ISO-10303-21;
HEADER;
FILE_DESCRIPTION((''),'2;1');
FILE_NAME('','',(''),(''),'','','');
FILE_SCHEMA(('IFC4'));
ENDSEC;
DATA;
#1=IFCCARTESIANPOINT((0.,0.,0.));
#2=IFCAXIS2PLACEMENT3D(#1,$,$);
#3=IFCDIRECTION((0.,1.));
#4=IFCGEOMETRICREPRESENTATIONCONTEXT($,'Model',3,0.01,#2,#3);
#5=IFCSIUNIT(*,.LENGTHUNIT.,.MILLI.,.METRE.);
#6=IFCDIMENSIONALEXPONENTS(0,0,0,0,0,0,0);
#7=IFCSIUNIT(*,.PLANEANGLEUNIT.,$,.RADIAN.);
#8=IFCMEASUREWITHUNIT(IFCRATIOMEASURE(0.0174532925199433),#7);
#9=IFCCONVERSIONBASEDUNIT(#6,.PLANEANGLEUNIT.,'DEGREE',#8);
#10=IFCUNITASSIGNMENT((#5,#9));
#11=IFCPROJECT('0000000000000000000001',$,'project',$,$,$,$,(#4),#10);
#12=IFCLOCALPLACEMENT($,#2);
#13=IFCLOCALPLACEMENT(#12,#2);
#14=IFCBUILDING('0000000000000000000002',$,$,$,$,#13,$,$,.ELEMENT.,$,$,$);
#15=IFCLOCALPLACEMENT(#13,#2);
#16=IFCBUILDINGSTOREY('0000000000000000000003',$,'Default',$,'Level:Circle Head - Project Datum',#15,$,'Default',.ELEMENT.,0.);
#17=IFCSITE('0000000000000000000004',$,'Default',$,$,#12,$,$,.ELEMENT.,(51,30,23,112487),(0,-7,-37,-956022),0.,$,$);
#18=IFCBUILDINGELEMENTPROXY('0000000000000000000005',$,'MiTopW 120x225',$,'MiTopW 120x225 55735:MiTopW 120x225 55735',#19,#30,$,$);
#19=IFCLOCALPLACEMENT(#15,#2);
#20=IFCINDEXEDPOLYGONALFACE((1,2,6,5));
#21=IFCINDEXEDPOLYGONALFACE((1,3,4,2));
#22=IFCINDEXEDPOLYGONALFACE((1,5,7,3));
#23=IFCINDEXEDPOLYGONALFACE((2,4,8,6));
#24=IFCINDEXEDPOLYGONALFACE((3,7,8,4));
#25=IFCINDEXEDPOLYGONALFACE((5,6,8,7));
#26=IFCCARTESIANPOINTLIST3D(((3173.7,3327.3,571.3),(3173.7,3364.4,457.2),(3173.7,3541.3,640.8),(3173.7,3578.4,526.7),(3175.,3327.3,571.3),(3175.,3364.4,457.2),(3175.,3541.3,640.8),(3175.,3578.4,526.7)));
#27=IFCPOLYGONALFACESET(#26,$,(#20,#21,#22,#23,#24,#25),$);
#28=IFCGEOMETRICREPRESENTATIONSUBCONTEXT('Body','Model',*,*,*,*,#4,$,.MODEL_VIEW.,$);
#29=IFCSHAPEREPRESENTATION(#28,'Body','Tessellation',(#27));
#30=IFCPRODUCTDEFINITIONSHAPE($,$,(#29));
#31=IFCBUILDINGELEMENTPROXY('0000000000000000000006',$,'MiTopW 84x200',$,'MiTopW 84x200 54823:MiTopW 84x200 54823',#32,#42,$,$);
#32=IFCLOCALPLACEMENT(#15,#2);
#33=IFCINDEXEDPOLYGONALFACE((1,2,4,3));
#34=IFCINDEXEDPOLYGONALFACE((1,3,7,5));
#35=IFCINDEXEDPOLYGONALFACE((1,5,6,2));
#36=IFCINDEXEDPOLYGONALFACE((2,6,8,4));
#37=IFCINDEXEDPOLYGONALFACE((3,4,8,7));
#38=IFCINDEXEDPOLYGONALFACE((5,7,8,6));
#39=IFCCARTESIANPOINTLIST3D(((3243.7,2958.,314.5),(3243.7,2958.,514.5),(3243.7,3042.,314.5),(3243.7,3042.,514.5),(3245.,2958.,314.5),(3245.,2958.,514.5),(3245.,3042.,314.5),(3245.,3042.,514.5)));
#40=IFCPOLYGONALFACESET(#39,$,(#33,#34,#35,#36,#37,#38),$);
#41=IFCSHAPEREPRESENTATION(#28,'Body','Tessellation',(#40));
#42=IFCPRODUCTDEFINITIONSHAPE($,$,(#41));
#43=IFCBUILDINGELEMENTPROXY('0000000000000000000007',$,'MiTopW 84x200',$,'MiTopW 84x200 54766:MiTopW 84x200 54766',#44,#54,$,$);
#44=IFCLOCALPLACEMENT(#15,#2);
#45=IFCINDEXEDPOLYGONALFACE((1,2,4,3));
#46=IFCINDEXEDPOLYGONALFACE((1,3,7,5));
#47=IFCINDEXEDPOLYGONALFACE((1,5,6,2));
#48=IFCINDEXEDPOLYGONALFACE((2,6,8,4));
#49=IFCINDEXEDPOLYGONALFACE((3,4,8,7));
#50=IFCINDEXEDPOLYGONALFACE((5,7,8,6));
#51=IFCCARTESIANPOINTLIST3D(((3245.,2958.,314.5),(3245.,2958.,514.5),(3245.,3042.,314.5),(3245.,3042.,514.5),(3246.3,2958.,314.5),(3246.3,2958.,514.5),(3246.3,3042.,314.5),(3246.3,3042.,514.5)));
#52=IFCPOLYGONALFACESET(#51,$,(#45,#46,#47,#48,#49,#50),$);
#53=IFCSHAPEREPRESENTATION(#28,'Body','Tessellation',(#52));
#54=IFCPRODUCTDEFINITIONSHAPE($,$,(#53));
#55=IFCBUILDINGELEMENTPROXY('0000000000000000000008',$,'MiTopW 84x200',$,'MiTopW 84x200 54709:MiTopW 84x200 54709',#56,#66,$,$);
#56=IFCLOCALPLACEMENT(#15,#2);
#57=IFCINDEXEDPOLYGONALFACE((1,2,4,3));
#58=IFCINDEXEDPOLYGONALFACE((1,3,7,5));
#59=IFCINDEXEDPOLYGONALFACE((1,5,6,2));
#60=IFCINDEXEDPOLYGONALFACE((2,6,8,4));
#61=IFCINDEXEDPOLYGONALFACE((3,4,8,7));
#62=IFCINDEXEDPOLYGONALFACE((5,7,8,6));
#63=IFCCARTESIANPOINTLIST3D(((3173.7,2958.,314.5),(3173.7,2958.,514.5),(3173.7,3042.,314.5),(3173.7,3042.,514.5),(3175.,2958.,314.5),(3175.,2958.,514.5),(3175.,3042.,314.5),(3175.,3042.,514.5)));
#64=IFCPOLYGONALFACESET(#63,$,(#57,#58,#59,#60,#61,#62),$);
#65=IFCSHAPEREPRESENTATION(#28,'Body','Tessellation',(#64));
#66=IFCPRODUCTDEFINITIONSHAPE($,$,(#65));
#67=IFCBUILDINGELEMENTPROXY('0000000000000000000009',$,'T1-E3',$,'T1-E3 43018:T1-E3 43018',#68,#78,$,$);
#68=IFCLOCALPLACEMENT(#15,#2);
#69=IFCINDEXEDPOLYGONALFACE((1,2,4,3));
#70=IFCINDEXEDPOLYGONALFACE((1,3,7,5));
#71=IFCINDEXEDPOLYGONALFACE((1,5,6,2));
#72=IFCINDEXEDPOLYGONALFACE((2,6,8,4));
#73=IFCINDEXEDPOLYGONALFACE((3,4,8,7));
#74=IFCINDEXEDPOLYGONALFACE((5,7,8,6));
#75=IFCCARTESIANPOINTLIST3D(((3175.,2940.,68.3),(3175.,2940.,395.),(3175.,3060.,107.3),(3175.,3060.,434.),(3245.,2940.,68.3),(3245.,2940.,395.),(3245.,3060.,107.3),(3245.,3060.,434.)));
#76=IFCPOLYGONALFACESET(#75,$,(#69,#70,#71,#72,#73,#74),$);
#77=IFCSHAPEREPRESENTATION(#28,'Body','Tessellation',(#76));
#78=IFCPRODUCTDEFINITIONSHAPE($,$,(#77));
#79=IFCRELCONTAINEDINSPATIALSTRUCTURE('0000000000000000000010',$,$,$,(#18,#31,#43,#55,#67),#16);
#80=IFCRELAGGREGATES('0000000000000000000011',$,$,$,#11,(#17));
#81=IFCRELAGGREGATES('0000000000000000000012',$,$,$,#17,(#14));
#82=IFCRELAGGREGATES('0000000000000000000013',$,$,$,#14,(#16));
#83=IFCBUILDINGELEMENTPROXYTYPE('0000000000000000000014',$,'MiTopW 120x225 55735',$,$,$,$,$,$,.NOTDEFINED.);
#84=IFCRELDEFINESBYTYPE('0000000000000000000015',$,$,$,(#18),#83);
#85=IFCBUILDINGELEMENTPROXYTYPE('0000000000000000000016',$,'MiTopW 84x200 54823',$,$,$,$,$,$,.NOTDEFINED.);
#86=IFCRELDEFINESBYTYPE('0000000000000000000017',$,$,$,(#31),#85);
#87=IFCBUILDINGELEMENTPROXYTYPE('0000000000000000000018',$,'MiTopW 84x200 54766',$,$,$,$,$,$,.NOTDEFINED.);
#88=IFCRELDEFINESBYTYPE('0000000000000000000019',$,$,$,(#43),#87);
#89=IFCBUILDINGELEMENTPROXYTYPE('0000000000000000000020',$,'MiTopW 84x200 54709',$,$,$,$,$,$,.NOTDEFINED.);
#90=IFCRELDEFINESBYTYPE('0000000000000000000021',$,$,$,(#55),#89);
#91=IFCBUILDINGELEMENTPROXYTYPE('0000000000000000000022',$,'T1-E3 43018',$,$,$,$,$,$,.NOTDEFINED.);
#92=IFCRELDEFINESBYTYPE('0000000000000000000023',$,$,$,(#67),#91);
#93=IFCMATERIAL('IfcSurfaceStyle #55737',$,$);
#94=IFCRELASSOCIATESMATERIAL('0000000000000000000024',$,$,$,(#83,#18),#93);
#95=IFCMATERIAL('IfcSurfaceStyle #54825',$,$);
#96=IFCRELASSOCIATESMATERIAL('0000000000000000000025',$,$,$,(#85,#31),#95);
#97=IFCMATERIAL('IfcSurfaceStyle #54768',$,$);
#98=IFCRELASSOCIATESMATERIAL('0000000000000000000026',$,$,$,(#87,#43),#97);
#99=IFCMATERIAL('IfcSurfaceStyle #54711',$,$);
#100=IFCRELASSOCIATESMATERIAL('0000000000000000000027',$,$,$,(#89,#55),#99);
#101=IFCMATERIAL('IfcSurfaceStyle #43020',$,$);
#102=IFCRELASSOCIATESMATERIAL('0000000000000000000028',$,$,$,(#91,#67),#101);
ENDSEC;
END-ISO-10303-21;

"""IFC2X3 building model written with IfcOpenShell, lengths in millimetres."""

from ifc_helpers import new_model, entity, si_unit, converted_unit, direction, frame, frame_2d, origin, place, context, subcontext, project, spatial, polyline, rectangle, outline, extrude, source, transform, mapped, material, type_object, type_shapes, element, save


model = new_model("IFC2X3")

# Units and contexts
model_context = context("Model", 3, precision=0.01, world=origin(), true_north=direction((0.0, 1.0)))
body_context = subcontext(model_context, "Body", "Model", "MODEL_VIEW")
ifc_project = project(units=[si_unit("LENGTHUNIT", "METRE", prefix="MILLI"), converted_unit("PLANEANGLEUNIT", "DEGREE", entity("IfcRatioMeasure", 0.0174532925199433), si_unit("PLANEANGLEUNIT", "RADIAN"), dimensions=[0, 0, 0, 0, 0, 0, 0])], contexts=[model_context])

# Site, building, storey
site_placement = place(None, origin())
site = spatial("IfcSite", under=ifc_project, at=site_placement, Name="Default", CompositionType="ELEMENT", RefLatitude=(51, 30, 23, 112487), RefLongitude=(0, -7, -37, -956022), RefElevation=0.0)
building_placement = place(site_placement, origin())
building = spatial("IfcBuilding", under=site, at=building_placement, CompositionType="ELEMENT")
storey_placement = place(building_placement, origin())
storey = spatial("IfcBuildingStorey", under=building, at=storey_placement, Name="Default", ObjectType="Level:Circle Head - Project Datum", LongName="Default", CompositionType="ELEMENT", Elevation=0.0)

# Building element proxies
ifc_material_1 = material(Name="IfcSurfaceStyle #55737")
building_element_proxy_type_1 = type_object("IfcBuildingElementProxyType", Name="MiTopW 120x225 55735", PredefinedType="NOTDEFINED", material=ifc_material_1)
shared_shape_1 = source(origin(), body_context, "Body", "SweptSolid", [
    extrude(outline(polyline([(-112.5, -60.0), (112.5, -60.0), (112.5, 60.0), (-112.5, 60.0), (-112.5, -60.0)])), frame((112.5, 60.0, 0.0), z_axis=(0.0, 0.0, 1.0), x_axis=(-1.0, 0.0, 0.0)), (0.0, 0.0, 1.0), 1.3),
])
type_shapes(building_element_proxy_type_1, [shared_shape_1])
proxy_1_placement = place(building_placement, frame((3175.0, 3327.3, 571.3), z_axis=(-1.0, 0.0, 0.0), x_axis=(0.0, 0.951057, 0.309017)))
element("IfcBuildingElementProxy", 1, at=proxy_1_placement, inside=storey, type_object=building_element_proxy_type_1, material=ifc_material_1, Name="MiTopW 120x225", ObjectType="MiTopW 120x225 55735:MiTopW 120x225 55735", context=body_context, shape_type="MappedRepresentation", body=[
    mapped(shared_shape_1, transform((0.0, 0.0, 0.0), scale=1.0)),
])
ifc_material_2 = material(Name="IfcSurfaceStyle #54825")
building_element_proxy_type_2 = type_object("IfcBuildingElementProxyType", Name="MiTopW 84x200 54823", PredefinedType="NOTDEFINED", material=ifc_material_2)
shared_shape_2 = source(origin(), body_context, "Body", "SweptSolid", [
    extrude(rectangle(XDim=200.0, YDim=84.0, at=frame_2d((0.0, 0.0), x_axis=(1.0, 0.0))), frame((100.0, 42.0, 0.0), z_axis=(0.0, 0.0, 1.0), x_axis=(-1.0, 0.0, 0.0)), (0.0, 0.0, 1.0), 1.3),
])
type_shapes(building_element_proxy_type_2, [shared_shape_2])
proxy_2_placement = place(building_placement, frame((3245.0, 3042.0, 514.5), z_axis=(-1.0, 0.0, 0.0), x_axis=(0.0, 0.0, -1.0)))
element("IfcBuildingElementProxy", 2, at=proxy_2_placement, inside=storey, type_object=building_element_proxy_type_2, material=ifc_material_2, Name="MiTopW 84x200", ObjectType="MiTopW 84x200 54823:MiTopW 84x200 54823", context=body_context, shape_type="MappedRepresentation", body=[
    mapped(shared_shape_2, transform((0.0, 0.0, 0.0), scale=1.0)),
])
ifc_material_3 = material(Name="IfcSurfaceStyle #54768")
building_element_proxy_type_3 = type_object("IfcBuildingElementProxyType", Name="MiTopW 84x200 54766", PredefinedType="NOTDEFINED", material=ifc_material_3)
shared_shape_3 = source(origin(), body_context, "Body", "SweptSolid", [
    extrude(rectangle(XDim=200.0, YDim=84.0, at=frame_2d((0.0, 0.0), x_axis=(1.0, 0.0))), frame((100.0, 42.0, 0.0), z_axis=(0.0, 0.0, 1.0), x_axis=(-1.0, 0.0, 0.0)), (0.0, 0.0, 1.0), 1.3),
])
type_shapes(building_element_proxy_type_3, [shared_shape_3])
proxy_3_placement = place(building_placement, frame((3246.3, 3042.0, 514.5), z_axis=(-1.0, 0.0, 0.0), x_axis=(0.0, 0.0, -1.0)))
element("IfcBuildingElementProxy", 3, at=proxy_3_placement, inside=storey, type_object=building_element_proxy_type_3, material=ifc_material_3, Name="MiTopW 84x200", ObjectType="MiTopW 84x200 54766:MiTopW 84x200 54766", context=body_context, shape_type="MappedRepresentation", body=[
    mapped(shared_shape_3, transform((0.0, 0.0, 0.0), scale=1.0)),
])
ifc_material_4 = material(Name="IfcSurfaceStyle #54711")
building_element_proxy_type_4 = type_object("IfcBuildingElementProxyType", Name="MiTopW 84x200 54709", PredefinedType="NOTDEFINED", material=ifc_material_4)
shared_shape_4 = source(origin(), body_context, "Body", "SweptSolid", [
    extrude(rectangle(XDim=200.0, YDim=84.0, at=frame_2d((0.0, 0.0), x_axis=(1.0, 0.0))), frame((100.0, 42.0, 0.0), z_axis=(0.0, 0.0, 1.0), x_axis=(-1.0, 0.0, 0.0)), (0.0, 0.0, 1.0), 1.3),
])
type_shapes(building_element_proxy_type_4, [shared_shape_4])
proxy_4_placement = place(building_placement, frame((3175.0, 3042.0, 514.5), z_axis=(-1.0, 0.0, 0.0), x_axis=(0.0, 0.0, -1.0)))
element("IfcBuildingElementProxy", 4, at=proxy_4_placement, inside=storey, type_object=building_element_proxy_type_4, material=ifc_material_4, Name="MiTopW 84x200", ObjectType="MiTopW 84x200 54709:MiTopW 84x200 54709", context=body_context, shape_type="MappedRepresentation", body=[
    mapped(shared_shape_4, transform((0.0, 0.0, 0.0), scale=1.0)),
])
ifc_material_5 = material(Name="IfcSurfaceStyle #43020")
building_element_proxy_type_5 = type_object("IfcBuildingElementProxyType", Name="T1-E3 43018", PredefinedType="NOTDEFINED", material=ifc_material_5)
shared_shape_5 = source(origin(), body_context, "Body", "SweptSolid", [
    extrude(outline(polyline([(-182.8, -60.0), (143.8, -60.0), (182.8, 60.0), (-143.8, 60.0), (-182.8, -60.0)])), frame((182.8, 60.0, 0.0), z_axis=(0.0, 0.0, 1.0), x_axis=(-1.0, 0.0, 0.0)), (0.0, 0.0, 1.0), 70.0),
])
type_shapes(building_element_proxy_type_5, [shared_shape_5])
proxy_5_placement = place(building_placement, frame((3245.0, 2940.0, 68.3), z_axis=(-1.0, 0.0, 0.0), x_axis=(0.0, 0.0, 1.0)))
element("IfcBuildingElementProxy", 5, at=proxy_5_placement, inside=storey, type_object=building_element_proxy_type_5, material=ifc_material_5, Name="T1-E3", ObjectType="T1-E3 43018:T1-E3 43018", context=body_context, shape_type="MappedRepresentation", body=[
    mapped(shared_shape_5, transform((0.0, 0.0, 0.0), scale=1.0)),
])

save(model, "model.ifc")
